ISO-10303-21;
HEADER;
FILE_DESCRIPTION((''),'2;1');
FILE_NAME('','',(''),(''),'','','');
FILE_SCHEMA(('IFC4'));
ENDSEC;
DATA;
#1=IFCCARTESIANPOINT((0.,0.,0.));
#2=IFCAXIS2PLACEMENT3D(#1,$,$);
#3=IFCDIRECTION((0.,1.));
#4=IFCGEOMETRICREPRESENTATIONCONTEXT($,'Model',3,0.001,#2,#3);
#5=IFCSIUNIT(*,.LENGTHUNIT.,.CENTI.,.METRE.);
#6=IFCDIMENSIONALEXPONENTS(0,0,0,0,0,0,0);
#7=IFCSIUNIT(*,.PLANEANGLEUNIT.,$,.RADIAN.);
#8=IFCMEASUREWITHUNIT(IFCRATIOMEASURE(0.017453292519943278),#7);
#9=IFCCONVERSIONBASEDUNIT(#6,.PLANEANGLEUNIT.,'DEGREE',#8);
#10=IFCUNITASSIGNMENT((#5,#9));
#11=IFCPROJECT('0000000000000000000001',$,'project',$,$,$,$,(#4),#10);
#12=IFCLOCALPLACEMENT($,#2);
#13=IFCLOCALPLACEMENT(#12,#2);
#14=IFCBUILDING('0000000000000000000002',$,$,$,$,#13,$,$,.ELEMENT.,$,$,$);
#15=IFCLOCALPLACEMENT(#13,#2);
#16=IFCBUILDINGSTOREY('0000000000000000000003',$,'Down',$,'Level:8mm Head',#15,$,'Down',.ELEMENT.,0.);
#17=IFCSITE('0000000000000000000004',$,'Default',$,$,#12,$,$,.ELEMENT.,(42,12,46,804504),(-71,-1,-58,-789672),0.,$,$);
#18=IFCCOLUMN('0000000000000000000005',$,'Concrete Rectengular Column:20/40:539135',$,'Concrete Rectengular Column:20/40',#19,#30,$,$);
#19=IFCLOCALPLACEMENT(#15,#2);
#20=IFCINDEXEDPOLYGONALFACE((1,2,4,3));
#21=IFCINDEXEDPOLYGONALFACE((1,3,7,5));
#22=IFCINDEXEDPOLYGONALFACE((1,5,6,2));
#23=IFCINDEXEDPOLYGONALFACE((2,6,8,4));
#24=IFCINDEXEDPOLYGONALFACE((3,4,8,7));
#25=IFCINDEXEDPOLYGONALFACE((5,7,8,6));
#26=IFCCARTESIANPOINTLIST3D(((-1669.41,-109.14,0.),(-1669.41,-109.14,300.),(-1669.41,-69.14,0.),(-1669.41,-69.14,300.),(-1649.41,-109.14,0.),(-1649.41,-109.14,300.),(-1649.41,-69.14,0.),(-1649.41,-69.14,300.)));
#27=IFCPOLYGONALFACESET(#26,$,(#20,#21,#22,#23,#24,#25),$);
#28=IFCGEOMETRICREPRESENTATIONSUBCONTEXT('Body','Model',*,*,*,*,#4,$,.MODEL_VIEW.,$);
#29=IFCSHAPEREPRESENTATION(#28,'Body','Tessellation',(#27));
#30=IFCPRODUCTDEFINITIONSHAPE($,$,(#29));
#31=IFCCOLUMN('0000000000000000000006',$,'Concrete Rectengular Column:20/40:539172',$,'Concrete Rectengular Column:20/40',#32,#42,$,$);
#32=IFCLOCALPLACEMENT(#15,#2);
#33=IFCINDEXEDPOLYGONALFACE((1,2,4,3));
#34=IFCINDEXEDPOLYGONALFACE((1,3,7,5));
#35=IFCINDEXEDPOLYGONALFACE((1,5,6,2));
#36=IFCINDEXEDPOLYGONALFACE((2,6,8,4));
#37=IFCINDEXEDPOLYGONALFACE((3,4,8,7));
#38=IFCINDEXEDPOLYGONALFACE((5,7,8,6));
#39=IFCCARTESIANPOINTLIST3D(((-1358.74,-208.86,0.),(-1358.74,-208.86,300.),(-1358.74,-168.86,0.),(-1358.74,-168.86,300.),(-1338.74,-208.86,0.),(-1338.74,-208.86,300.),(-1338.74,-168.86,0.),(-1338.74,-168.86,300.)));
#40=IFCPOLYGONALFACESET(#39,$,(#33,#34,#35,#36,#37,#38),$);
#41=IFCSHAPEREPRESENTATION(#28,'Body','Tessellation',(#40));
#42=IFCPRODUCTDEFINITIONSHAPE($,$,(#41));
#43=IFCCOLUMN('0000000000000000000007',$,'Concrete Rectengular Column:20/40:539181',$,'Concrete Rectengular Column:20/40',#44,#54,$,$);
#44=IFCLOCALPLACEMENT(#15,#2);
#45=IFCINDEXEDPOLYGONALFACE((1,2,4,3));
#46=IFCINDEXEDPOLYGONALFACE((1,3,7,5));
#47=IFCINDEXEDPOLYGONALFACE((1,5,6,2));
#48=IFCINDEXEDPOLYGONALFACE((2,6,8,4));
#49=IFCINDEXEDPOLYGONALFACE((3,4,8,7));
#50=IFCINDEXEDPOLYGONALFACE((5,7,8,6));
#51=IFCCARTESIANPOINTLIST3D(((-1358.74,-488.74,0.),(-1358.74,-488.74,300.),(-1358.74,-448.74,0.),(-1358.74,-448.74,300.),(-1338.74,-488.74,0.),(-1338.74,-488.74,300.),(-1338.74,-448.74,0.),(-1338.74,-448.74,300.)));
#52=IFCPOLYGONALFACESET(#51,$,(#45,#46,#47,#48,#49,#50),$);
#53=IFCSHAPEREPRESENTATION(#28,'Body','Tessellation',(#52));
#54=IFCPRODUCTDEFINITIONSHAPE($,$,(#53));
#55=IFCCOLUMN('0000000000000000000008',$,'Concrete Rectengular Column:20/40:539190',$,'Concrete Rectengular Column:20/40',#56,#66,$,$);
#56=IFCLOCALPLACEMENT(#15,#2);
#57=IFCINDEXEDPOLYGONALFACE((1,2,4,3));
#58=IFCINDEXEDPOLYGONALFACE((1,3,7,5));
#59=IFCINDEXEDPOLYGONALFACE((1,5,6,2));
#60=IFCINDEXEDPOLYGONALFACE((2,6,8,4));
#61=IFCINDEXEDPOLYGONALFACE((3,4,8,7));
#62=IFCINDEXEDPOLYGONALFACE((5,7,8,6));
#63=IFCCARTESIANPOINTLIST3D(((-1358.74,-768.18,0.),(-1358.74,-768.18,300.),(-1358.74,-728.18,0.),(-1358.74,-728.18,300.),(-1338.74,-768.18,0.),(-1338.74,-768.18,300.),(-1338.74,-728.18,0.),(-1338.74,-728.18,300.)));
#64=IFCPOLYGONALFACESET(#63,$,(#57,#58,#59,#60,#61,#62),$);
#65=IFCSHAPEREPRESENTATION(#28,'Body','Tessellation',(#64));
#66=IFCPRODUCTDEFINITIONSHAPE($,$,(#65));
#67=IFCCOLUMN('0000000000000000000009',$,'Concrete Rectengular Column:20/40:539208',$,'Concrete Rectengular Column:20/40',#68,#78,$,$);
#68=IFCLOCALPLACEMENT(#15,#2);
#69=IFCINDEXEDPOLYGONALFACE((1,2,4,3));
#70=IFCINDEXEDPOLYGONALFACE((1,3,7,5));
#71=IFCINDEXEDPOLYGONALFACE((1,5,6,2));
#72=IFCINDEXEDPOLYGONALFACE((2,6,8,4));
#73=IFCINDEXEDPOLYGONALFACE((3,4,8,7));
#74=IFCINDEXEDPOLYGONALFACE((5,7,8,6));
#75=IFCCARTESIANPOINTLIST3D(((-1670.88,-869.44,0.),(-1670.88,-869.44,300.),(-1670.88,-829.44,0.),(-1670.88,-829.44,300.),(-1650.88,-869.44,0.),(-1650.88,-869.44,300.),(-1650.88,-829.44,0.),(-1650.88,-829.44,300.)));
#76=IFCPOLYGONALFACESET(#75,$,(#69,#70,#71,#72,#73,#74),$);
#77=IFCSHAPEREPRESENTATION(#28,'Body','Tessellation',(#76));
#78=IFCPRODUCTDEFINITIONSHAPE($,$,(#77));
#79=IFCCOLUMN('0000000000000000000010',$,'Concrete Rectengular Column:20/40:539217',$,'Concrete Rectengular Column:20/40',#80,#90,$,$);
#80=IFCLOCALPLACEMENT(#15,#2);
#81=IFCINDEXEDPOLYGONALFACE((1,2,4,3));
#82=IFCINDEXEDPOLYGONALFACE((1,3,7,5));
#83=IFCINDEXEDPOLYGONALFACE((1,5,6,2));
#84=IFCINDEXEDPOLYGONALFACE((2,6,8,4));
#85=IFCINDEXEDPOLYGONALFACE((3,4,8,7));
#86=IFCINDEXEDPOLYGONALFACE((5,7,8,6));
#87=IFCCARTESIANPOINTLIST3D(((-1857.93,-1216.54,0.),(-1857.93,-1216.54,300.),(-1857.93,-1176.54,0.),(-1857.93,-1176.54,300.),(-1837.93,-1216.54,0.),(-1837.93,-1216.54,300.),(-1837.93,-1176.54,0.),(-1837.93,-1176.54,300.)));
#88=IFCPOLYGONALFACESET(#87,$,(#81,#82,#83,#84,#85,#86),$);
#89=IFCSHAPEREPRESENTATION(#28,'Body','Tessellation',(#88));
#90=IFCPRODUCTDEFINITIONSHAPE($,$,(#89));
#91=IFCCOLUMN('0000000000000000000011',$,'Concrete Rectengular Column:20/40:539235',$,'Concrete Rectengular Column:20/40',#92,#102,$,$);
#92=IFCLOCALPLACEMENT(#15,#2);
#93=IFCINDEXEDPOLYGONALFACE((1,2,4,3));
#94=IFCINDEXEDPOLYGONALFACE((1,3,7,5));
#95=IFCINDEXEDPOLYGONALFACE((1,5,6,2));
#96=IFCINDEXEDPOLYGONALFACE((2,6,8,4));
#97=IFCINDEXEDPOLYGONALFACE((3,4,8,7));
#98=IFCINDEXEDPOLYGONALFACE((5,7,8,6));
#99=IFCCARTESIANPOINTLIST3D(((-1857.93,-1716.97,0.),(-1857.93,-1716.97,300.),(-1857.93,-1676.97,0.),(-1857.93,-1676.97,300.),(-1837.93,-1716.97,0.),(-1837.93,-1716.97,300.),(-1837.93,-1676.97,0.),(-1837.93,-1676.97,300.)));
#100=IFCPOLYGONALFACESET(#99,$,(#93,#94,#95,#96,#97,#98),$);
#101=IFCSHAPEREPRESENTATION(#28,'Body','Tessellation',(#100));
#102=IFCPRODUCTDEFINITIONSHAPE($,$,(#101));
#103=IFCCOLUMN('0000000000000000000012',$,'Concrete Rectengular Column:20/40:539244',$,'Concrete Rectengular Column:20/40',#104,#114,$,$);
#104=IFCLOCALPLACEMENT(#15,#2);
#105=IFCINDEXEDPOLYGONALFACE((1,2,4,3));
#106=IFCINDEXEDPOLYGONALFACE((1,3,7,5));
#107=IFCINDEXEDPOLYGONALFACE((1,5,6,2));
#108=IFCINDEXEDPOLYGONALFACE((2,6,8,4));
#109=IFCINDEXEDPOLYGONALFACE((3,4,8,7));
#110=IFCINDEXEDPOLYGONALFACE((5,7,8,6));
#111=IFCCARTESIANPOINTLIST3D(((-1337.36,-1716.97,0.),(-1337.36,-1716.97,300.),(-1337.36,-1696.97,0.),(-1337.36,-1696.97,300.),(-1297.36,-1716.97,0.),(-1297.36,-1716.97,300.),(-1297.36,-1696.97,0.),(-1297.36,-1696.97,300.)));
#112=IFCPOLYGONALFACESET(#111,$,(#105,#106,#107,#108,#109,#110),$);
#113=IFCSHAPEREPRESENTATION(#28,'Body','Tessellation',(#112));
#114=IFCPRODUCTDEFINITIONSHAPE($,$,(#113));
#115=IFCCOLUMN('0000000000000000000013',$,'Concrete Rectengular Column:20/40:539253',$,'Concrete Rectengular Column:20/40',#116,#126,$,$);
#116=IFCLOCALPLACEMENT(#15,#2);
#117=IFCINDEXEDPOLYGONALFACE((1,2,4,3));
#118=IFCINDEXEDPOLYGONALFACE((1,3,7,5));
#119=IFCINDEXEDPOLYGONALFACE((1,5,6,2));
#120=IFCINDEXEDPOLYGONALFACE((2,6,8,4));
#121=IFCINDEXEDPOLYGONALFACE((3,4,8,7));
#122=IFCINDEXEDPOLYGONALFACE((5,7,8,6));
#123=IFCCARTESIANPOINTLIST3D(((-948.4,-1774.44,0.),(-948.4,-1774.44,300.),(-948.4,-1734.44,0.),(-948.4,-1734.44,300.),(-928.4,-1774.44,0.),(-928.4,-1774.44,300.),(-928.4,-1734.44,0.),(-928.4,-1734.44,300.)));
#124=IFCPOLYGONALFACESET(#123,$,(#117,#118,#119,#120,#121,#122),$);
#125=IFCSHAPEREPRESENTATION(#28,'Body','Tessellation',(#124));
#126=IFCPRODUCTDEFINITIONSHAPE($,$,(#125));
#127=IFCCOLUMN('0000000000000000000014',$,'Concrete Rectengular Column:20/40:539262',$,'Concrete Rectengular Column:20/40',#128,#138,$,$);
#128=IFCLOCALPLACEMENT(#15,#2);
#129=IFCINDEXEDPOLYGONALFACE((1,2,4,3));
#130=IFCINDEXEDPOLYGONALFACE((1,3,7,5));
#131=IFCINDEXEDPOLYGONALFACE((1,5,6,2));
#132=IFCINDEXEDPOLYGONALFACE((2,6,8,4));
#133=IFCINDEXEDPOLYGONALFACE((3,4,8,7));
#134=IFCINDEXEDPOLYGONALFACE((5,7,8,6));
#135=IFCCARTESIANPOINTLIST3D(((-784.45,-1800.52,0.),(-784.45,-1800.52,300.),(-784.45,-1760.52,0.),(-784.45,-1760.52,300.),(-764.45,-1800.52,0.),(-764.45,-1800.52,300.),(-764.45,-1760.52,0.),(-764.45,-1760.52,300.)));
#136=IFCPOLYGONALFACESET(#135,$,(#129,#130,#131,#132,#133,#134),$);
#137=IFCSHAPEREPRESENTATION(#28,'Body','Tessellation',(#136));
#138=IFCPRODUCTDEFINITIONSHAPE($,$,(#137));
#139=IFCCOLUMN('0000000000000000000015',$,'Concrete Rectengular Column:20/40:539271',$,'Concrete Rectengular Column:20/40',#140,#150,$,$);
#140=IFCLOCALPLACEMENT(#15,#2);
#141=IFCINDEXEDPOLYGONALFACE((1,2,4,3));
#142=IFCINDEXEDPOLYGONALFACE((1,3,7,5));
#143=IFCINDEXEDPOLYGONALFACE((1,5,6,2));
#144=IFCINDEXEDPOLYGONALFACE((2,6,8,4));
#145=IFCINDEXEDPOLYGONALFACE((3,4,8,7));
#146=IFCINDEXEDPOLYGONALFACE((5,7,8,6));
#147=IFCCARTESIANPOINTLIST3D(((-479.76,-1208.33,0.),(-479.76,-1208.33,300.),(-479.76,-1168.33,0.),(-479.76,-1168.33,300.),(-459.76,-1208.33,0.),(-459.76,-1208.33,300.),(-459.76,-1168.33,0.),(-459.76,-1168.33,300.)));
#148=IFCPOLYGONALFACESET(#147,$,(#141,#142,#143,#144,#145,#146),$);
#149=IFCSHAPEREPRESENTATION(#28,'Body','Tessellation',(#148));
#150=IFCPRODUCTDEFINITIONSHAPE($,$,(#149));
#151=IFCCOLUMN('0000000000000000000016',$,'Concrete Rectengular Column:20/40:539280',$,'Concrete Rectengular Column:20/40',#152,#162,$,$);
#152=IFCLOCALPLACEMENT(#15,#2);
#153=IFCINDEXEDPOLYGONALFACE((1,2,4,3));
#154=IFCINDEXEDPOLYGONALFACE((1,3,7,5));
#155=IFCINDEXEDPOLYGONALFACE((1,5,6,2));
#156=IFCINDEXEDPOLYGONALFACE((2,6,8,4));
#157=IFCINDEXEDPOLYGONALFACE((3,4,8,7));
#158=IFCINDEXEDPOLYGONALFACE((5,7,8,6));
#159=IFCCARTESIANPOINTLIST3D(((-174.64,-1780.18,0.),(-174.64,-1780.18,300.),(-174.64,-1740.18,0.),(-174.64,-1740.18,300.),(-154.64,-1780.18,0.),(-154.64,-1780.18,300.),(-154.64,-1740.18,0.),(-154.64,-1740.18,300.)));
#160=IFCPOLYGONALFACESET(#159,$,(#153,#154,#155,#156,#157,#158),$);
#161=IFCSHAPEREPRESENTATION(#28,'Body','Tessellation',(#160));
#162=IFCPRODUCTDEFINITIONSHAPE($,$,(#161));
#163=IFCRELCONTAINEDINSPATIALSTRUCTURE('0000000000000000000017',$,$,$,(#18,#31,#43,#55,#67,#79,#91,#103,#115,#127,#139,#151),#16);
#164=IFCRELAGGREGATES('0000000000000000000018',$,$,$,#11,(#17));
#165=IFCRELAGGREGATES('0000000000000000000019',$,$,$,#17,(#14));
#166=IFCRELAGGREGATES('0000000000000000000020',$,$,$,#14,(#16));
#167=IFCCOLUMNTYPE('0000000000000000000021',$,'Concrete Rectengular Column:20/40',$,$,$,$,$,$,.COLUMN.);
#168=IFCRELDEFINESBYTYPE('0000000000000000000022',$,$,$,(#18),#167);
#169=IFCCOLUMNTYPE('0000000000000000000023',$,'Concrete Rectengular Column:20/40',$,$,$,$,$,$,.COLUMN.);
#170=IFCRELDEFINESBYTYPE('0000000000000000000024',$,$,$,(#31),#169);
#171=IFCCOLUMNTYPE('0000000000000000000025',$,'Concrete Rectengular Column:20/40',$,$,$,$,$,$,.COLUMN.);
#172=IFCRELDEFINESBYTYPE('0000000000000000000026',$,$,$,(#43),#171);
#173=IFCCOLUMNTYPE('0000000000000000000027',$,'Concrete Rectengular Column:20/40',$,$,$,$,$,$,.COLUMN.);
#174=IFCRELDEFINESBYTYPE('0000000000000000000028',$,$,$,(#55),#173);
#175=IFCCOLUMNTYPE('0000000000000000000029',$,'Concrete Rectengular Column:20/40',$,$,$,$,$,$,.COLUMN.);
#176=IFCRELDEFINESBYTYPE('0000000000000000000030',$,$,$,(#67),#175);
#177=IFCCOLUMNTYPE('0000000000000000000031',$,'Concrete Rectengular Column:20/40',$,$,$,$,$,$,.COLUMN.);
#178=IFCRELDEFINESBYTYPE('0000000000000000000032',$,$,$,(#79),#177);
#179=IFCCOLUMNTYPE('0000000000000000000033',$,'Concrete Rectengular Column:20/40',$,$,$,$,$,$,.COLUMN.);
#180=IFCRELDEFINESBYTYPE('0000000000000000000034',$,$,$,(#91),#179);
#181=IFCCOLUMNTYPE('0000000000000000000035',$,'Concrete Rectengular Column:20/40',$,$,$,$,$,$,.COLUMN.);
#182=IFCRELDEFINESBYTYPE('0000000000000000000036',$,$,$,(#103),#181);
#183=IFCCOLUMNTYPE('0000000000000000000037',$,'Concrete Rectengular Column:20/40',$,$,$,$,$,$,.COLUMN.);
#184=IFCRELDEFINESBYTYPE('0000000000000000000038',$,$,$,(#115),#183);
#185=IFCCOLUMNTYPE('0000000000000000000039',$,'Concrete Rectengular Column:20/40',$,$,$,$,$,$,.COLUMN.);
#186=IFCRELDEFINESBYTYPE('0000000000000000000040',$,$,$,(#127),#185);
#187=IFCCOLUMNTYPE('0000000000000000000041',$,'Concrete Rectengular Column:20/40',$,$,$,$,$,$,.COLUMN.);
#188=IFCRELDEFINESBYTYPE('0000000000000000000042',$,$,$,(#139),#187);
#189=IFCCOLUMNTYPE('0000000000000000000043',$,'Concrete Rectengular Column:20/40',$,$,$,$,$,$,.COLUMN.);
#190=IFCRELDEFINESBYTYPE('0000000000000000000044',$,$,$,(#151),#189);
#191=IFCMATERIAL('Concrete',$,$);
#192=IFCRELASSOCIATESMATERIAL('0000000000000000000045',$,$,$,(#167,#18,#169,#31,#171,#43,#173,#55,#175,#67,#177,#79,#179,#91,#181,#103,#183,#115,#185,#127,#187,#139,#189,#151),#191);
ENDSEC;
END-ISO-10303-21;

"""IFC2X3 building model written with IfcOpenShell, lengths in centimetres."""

from ifc_helpers import new_model, entity, si_unit, converted_unit, direction, frame, frame_2d, origin, origin_2d_with_axis, place, context, subcontext, project, spatial, rectangle, extrude, source, transform, mapped, material, type_object, type_shapes, element, save


model = new_model("IFC2X3")

# Units and contexts
model_context = context("Model", 3, precision=0.001, world=origin(), true_north=direction((0.0, 1.0)))
body_context = subcontext(model_context, "Body", "Model", "MODEL_VIEW")
ifc_project = project(units=[si_unit("LENGTHUNIT", "METRE", prefix="CENTI"), converted_unit("PLANEANGLEUNIT", "DEGREE", entity("IfcRatioMeasure", 0.017453292519943278), si_unit("PLANEANGLEUNIT", "RADIAN"), dimensions=[0, 0, 0, 0, 0, 0, 0])], contexts=[model_context])

# Site, building, storey
site_placement = place(None, origin())
site = spatial("IfcSite", under=ifc_project, at=site_placement, Name="Default", CompositionType="ELEMENT", RefLatitude=(42, 12, 46, 804504), RefLongitude=(-71, -1, -58, -789672), RefElevation=0.0)
building_placement = place(site_placement, origin())
building = spatial("IfcBuilding", under=site, at=building_placement, CompositionType="ELEMENT")
storey_placement = place(building_placement, origin())
storey = spatial("IfcBuildingStorey", under=building, at=storey_placement, Name="Down", ObjectType="Level:8mm Head", LongName="Down", CompositionType="ELEMENT", Elevation=0.0)

# Columns
ifc_material = material(Name="Concrete")
column_type_1 = type_object("IfcColumnType", Name="Concrete Rectengular Column:20/40", PredefinedType="COLUMN", material=ifc_material)
shared_shape_1 = source(origin(), body_context, "Body", "SweptSolid", [
    extrude(rectangle(XDim=40.0, YDim=20.0, at=frame_2d((0.0, 0.0), x_axis=(1.0, 0.0))), frame((-1659.41, -89.14, 0.0), z_axis=(0.0, 0.0, 1.0), x_axis=(0.0, -1.0, 0.0)), (0.0, 0.0, 1.0), 300.0),
])
type_shapes(column_type_1, [shared_shape_1])
column_1_placement = place(storey_placement, origin())
element("IfcColumn", 1, at=column_1_placement, inside=storey, type_object=column_type_1, material=ifc_material, Name="Concrete Rectengular Column:20/40:539135", ObjectType="Concrete Rectengular Column:20/40", context=body_context, shape_type="MappedRepresentation", body=[
    mapped(shared_shape_1, transform((0.0, 0.0, 0.0), scale=1.0)),
])
column_type_2 = type_object("IfcColumnType", Name="Concrete Rectengular Column:20/40", PredefinedType="COLUMN", material=ifc_material)
shared_shape_2 = source(origin(), body_context, "Body", "SweptSolid", [
    extrude(rectangle(XDim=40.0, YDim=20.0, at=frame_2d((0.0, 0.0), x_axis=(1.0, 0.0))), frame((-1348.74, -188.86, 0.0), z_axis=(0.0, 0.0, 1.0), x_axis=(0.0, -1.0, 0.0)), (0.0, 0.0, 1.0), 300.0),
])
type_shapes(column_type_2, [shared_shape_2])
column_2_placement = place(storey_placement, origin())
element("IfcColumn", 2, at=column_2_placement, inside=storey, type_object=column_type_2, material=ifc_material, Name="Concrete Rectengular Column:20/40:539172", ObjectType="Concrete Rectengular Column:20/40", context=body_context, shape_type="MappedRepresentation", body=[
    mapped(shared_shape_2, transform((0.0, 0.0, 0.0), scale=1.0)),
])
column_type_3 = type_object("IfcColumnType", Name="Concrete Rectengular Column:20/40", PredefinedType="COLUMN", material=ifc_material)
shared_shape_3 = source(origin(), body_context, "Body", "SweptSolid", [
    extrude(rectangle(XDim=40.0, YDim=20.0, at=frame_2d((0.0, 0.0), x_axis=(1.0, 0.0))), frame((-1348.74, -468.74, 0.0), z_axis=(0.0, 0.0, 1.0), x_axis=(0.0, -1.0, 0.0)), (0.0, 0.0, 1.0), 300.0),
])
type_shapes(column_type_3, [shared_shape_3])
column_3_placement = place(storey_placement, origin())
element("IfcColumn", 3, at=column_3_placement, inside=storey, type_object=column_type_3, material=ifc_material, Name="Concrete Rectengular Column:20/40:539181", ObjectType="Concrete Rectengular Column:20/40", context=body_context, shape_type="MappedRepresentation", body=[
    mapped(shared_shape_3, transform((0.0, 0.0, 0.0), scale=1.0)),
])
column_type_4 = type_object("IfcColumnType", Name="Concrete Rectengular Column:20/40", PredefinedType="COLUMN", material=ifc_material)
shared_shape_4 = source(origin(), body_context, "Body", "SweptSolid", [
    extrude(rectangle(XDim=40.0, YDim=20.0, at=frame_2d((0.0, 0.0), x_axis=(1.0, 0.0))), frame((-1348.74, -748.18, 0.0), z_axis=(0.0, 0.0, 1.0), x_axis=(0.0, -1.0, 0.0)), (0.0, 0.0, 1.0), 300.0),
])
type_shapes(column_type_4, [shared_shape_4])
column_4_placement = place(storey_placement, origin())
element("IfcColumn", 4, at=column_4_placement, inside=storey, type_object=column_type_4, material=ifc_material, Name="Concrete Rectengular Column:20/40:539190", ObjectType="Concrete Rectengular Column:20/40", context=body_context, shape_type="MappedRepresentation", body=[
    mapped(shared_shape_4, transform((0.0, 0.0, 0.0), scale=1.0)),
])
column_type_5 = type_object("IfcColumnType", Name="Concrete Rectengular Column:20/40", PredefinedType="COLUMN", material=ifc_material)
shared_shape_5 = source(origin(), body_context, "Body", "SweptSolid", [
    extrude(rectangle(XDim=40.0, YDim=20.0, at=frame_2d((0.0, 0.0), x_axis=(1.0, 0.0))), frame((-1660.88, -849.44, 0.0), z_axis=(0.0, 0.0, 1.0), x_axis=(0.0, -1.0, 0.0)), (0.0, 0.0, 1.0), 300.0),
])
type_shapes(column_type_5, [shared_shape_5])
column_5_placement = place(storey_placement, origin())
element("IfcColumn", 5, at=column_5_placement, inside=storey, type_object=column_type_5, material=ifc_material, Name="Concrete Rectengular Column:20/40:539208", ObjectType="Concrete Rectengular Column:20/40", context=body_context, shape_type="MappedRepresentation", body=[
    mapped(shared_shape_5, transform((0.0, 0.0, 0.0), scale=1.0)),
])
column_type_6 = type_object("IfcColumnType", Name="Concrete Rectengular Column:20/40", PredefinedType="COLUMN", material=ifc_material)
shared_shape_6 = source(origin(), body_context, "Body", "SweptSolid", [
    extrude(rectangle(XDim=40.0, YDim=20.0, at=frame_2d((0.0, 0.0), x_axis=(1.0, 0.0))), frame((-1847.93, -1196.54, 0.0), z_axis=(0.0, 0.0, 1.0), x_axis=(0.0, -1.0, 0.0)), (0.0, 0.0, 1.0), 300.0),
])
type_shapes(column_type_6, [shared_shape_6])
column_6_placement = place(storey_placement, origin())
element("IfcColumn", 6, at=column_6_placement, inside=storey, type_object=column_type_6, material=ifc_material, Name="Concrete Rectengular Column:20/40:539217", ObjectType="Concrete Rectengular Column:20/40", context=body_context, shape_type="MappedRepresentation", body=[
    mapped(shared_shape_6, transform((0.0, 0.0, 0.0), scale=1.0)),
])
column_type_7 = type_object("IfcColumnType", Name="Concrete Rectengular Column:20/40", PredefinedType="COLUMN", material=ifc_material)
shared_shape_7 = source(origin(), body_context, "Body", "SweptSolid", [
    extrude(rectangle(XDim=40.0, YDim=20.0, at=frame_2d((0.0, 0.0), x_axis=(1.0, 0.0))), frame((-1847.93, -1696.97, 0.0), z_axis=(0.0, 0.0, 1.0), x_axis=(0.0, -1.0, 0.0)), (0.0, 0.0, 1.0), 300.0),
])
type_shapes(column_type_7, [shared_shape_7])
column_7_placement = place(storey_placement, origin())
element("IfcColumn", 7, at=column_7_placement, inside=storey, type_object=column_type_7, material=ifc_material, Name="Concrete Rectengular Column:20/40:539235", ObjectType="Concrete Rectengular Column:20/40", context=body_context, shape_type="MappedRepresentation", body=[
    mapped(shared_shape_7, transform((0.0, 0.0, 0.0), scale=1.0)),
])
column_type_8 = type_object("IfcColumnType", Name="Concrete Rectengular Column:20/40", PredefinedType="COLUMN", material=ifc_material)
shared_shape_8 = source(origin(), body_context, "Body", "SweptSolid", [
    extrude(rectangle(XDim=20.0, YDim=40.0, at=frame_2d((0.0, 0.0), x_axis=(1.0, 0.0))), frame((-1317.36, -1706.97, 0.0), z_axis=(0.0, 0.0, 1.0), x_axis=(0.0, -1.0, 0.0)), (0.0, 0.0, 1.0), 300.0),
])
type_shapes(column_type_8, [shared_shape_8])
column_8_placement = place(storey_placement, origin())
element("IfcColumn", 8, at=column_8_placement, inside=storey, type_object=column_type_8, material=ifc_material, Name="Concrete Rectengular Column:20/40:539244", ObjectType="Concrete Rectengular Column:20/40", context=body_context, shape_type="MappedRepresentation", body=[
    mapped(shared_shape_8, transform((0.0, 0.0, 0.0), scale=1.0)),
])
column_type_9 = type_object("IfcColumnType", Name="Concrete Rectengular Column:20/40", PredefinedType="COLUMN", material=ifc_material)
shared_shape_9 = source(origin(), body_context, "Body", "SweptSolid", [
    extrude(rectangle(XDim=40.0, YDim=20.0, at=frame_2d((0.0, 0.0), x_axis=(1.0, 0.0))), frame((-938.4, -1754.44, 0.0), z_axis=(0.0, 0.0, 1.0), x_axis=(0.0, -1.0, 0.0)), (0.0, 0.0, 1.0), 300.0),
])
type_shapes(column_type_9, [shared_shape_9])
column_9_placement = place(storey_placement, origin())
element("IfcColumn", 9, at=column_9_placement, inside=storey, type_object=column_type_9, material=ifc_material, Name="Concrete Rectengular Column:20/40:539253", ObjectType="Concrete Rectengular Column:20/40", context=body_context, shape_type="MappedRepresentation", body=[
    mapped(shared_shape_9, transform((0.0, 0.0, 0.0), scale=1.0)),
])
column_type_10 = type_object("IfcColumnType", Name="Concrete Rectengular Column:20/40", PredefinedType="COLUMN", material=ifc_material)
shared_shape_10 = source(origin(), body_context, "Body", "SweptSolid", [
    extrude(rectangle(XDim=40.0, YDim=20.0, at=origin_2d_with_axis()), frame((-774.45, -1780.52, 0.0), z_axis=(0.0, 0.0, 1.0), x_axis=(0.0, -1.0, 0.0)), (0.0, 0.0, 1.0), 300.0),
])
type_shapes(column_type_10, [shared_shape_10])
column_10_placement = place(storey_placement, origin())
element("IfcColumn", 10, at=column_10_placement, inside=storey, type_object=column_type_10, material=ifc_material, Name="Concrete Rectengular Column:20/40:539262", ObjectType="Concrete Rectengular Column:20/40", context=body_context, shape_type="MappedRepresentation", body=[
    mapped(shared_shape_10, transform((0.0, 0.0, 0.0), scale=1.0)),
])
column_type_11 = type_object("IfcColumnType", Name="Concrete Rectengular Column:20/40", PredefinedType="COLUMN", material=ifc_material)
shared_shape_11 = source(origin(), body_context, "Body", "SweptSolid", [
    extrude(rectangle(XDim=40.0, YDim=20.0, at=origin_2d_with_axis()), frame((-469.76, -1188.33, 0.0), z_axis=(0.0, 0.0, 1.0), x_axis=(0.0, -1.0, 0.0)), (0.0, 0.0, 1.0), 300.0),
])
type_shapes(column_type_11, [shared_shape_11])
column_11_placement = place(storey_placement, origin())
element("IfcColumn", 11, at=column_11_placement, inside=storey, type_object=column_type_11, material=ifc_material, Name="Concrete Rectengular Column:20/40:539271", ObjectType="Concrete Rectengular Column:20/40", context=body_context, shape_type="MappedRepresentation", body=[
    mapped(shared_shape_11, transform((0.0, 0.0, 0.0), scale=1.0)),
])
column_type_12 = type_object("IfcColumnType", Name="Concrete Rectengular Column:20/40", PredefinedType="COLUMN", material=ifc_material)
shared_shape_12 = source(origin(), body_context, "Body", "SweptSolid", [
    extrude(rectangle(XDim=40.0, YDim=20.0, at=frame_2d((0.0, 0.0), x_axis=(1.0, 0.0))), frame((-164.64, -1760.18, 0.0), z_axis=(0.0, 0.0, 1.0), x_axis=(0.0, -1.0, 0.0)), (0.0, 0.0, 1.0), 300.0),
])
type_shapes(column_type_12, [shared_shape_12])
column_12_placement = place(storey_placement, origin())
element("IfcColumn", 12, at=column_12_placement, inside=storey, type_object=column_type_12, material=ifc_material, Name="Concrete Rectengular Column:20/40:539280", ObjectType="Concrete Rectengular Column:20/40", context=body_context, shape_type="MappedRepresentation", body=[
    mapped(shared_shape_12, transform((0.0, 0.0, 0.0), scale=1.0)),
])

save(model, "model.ifc")
